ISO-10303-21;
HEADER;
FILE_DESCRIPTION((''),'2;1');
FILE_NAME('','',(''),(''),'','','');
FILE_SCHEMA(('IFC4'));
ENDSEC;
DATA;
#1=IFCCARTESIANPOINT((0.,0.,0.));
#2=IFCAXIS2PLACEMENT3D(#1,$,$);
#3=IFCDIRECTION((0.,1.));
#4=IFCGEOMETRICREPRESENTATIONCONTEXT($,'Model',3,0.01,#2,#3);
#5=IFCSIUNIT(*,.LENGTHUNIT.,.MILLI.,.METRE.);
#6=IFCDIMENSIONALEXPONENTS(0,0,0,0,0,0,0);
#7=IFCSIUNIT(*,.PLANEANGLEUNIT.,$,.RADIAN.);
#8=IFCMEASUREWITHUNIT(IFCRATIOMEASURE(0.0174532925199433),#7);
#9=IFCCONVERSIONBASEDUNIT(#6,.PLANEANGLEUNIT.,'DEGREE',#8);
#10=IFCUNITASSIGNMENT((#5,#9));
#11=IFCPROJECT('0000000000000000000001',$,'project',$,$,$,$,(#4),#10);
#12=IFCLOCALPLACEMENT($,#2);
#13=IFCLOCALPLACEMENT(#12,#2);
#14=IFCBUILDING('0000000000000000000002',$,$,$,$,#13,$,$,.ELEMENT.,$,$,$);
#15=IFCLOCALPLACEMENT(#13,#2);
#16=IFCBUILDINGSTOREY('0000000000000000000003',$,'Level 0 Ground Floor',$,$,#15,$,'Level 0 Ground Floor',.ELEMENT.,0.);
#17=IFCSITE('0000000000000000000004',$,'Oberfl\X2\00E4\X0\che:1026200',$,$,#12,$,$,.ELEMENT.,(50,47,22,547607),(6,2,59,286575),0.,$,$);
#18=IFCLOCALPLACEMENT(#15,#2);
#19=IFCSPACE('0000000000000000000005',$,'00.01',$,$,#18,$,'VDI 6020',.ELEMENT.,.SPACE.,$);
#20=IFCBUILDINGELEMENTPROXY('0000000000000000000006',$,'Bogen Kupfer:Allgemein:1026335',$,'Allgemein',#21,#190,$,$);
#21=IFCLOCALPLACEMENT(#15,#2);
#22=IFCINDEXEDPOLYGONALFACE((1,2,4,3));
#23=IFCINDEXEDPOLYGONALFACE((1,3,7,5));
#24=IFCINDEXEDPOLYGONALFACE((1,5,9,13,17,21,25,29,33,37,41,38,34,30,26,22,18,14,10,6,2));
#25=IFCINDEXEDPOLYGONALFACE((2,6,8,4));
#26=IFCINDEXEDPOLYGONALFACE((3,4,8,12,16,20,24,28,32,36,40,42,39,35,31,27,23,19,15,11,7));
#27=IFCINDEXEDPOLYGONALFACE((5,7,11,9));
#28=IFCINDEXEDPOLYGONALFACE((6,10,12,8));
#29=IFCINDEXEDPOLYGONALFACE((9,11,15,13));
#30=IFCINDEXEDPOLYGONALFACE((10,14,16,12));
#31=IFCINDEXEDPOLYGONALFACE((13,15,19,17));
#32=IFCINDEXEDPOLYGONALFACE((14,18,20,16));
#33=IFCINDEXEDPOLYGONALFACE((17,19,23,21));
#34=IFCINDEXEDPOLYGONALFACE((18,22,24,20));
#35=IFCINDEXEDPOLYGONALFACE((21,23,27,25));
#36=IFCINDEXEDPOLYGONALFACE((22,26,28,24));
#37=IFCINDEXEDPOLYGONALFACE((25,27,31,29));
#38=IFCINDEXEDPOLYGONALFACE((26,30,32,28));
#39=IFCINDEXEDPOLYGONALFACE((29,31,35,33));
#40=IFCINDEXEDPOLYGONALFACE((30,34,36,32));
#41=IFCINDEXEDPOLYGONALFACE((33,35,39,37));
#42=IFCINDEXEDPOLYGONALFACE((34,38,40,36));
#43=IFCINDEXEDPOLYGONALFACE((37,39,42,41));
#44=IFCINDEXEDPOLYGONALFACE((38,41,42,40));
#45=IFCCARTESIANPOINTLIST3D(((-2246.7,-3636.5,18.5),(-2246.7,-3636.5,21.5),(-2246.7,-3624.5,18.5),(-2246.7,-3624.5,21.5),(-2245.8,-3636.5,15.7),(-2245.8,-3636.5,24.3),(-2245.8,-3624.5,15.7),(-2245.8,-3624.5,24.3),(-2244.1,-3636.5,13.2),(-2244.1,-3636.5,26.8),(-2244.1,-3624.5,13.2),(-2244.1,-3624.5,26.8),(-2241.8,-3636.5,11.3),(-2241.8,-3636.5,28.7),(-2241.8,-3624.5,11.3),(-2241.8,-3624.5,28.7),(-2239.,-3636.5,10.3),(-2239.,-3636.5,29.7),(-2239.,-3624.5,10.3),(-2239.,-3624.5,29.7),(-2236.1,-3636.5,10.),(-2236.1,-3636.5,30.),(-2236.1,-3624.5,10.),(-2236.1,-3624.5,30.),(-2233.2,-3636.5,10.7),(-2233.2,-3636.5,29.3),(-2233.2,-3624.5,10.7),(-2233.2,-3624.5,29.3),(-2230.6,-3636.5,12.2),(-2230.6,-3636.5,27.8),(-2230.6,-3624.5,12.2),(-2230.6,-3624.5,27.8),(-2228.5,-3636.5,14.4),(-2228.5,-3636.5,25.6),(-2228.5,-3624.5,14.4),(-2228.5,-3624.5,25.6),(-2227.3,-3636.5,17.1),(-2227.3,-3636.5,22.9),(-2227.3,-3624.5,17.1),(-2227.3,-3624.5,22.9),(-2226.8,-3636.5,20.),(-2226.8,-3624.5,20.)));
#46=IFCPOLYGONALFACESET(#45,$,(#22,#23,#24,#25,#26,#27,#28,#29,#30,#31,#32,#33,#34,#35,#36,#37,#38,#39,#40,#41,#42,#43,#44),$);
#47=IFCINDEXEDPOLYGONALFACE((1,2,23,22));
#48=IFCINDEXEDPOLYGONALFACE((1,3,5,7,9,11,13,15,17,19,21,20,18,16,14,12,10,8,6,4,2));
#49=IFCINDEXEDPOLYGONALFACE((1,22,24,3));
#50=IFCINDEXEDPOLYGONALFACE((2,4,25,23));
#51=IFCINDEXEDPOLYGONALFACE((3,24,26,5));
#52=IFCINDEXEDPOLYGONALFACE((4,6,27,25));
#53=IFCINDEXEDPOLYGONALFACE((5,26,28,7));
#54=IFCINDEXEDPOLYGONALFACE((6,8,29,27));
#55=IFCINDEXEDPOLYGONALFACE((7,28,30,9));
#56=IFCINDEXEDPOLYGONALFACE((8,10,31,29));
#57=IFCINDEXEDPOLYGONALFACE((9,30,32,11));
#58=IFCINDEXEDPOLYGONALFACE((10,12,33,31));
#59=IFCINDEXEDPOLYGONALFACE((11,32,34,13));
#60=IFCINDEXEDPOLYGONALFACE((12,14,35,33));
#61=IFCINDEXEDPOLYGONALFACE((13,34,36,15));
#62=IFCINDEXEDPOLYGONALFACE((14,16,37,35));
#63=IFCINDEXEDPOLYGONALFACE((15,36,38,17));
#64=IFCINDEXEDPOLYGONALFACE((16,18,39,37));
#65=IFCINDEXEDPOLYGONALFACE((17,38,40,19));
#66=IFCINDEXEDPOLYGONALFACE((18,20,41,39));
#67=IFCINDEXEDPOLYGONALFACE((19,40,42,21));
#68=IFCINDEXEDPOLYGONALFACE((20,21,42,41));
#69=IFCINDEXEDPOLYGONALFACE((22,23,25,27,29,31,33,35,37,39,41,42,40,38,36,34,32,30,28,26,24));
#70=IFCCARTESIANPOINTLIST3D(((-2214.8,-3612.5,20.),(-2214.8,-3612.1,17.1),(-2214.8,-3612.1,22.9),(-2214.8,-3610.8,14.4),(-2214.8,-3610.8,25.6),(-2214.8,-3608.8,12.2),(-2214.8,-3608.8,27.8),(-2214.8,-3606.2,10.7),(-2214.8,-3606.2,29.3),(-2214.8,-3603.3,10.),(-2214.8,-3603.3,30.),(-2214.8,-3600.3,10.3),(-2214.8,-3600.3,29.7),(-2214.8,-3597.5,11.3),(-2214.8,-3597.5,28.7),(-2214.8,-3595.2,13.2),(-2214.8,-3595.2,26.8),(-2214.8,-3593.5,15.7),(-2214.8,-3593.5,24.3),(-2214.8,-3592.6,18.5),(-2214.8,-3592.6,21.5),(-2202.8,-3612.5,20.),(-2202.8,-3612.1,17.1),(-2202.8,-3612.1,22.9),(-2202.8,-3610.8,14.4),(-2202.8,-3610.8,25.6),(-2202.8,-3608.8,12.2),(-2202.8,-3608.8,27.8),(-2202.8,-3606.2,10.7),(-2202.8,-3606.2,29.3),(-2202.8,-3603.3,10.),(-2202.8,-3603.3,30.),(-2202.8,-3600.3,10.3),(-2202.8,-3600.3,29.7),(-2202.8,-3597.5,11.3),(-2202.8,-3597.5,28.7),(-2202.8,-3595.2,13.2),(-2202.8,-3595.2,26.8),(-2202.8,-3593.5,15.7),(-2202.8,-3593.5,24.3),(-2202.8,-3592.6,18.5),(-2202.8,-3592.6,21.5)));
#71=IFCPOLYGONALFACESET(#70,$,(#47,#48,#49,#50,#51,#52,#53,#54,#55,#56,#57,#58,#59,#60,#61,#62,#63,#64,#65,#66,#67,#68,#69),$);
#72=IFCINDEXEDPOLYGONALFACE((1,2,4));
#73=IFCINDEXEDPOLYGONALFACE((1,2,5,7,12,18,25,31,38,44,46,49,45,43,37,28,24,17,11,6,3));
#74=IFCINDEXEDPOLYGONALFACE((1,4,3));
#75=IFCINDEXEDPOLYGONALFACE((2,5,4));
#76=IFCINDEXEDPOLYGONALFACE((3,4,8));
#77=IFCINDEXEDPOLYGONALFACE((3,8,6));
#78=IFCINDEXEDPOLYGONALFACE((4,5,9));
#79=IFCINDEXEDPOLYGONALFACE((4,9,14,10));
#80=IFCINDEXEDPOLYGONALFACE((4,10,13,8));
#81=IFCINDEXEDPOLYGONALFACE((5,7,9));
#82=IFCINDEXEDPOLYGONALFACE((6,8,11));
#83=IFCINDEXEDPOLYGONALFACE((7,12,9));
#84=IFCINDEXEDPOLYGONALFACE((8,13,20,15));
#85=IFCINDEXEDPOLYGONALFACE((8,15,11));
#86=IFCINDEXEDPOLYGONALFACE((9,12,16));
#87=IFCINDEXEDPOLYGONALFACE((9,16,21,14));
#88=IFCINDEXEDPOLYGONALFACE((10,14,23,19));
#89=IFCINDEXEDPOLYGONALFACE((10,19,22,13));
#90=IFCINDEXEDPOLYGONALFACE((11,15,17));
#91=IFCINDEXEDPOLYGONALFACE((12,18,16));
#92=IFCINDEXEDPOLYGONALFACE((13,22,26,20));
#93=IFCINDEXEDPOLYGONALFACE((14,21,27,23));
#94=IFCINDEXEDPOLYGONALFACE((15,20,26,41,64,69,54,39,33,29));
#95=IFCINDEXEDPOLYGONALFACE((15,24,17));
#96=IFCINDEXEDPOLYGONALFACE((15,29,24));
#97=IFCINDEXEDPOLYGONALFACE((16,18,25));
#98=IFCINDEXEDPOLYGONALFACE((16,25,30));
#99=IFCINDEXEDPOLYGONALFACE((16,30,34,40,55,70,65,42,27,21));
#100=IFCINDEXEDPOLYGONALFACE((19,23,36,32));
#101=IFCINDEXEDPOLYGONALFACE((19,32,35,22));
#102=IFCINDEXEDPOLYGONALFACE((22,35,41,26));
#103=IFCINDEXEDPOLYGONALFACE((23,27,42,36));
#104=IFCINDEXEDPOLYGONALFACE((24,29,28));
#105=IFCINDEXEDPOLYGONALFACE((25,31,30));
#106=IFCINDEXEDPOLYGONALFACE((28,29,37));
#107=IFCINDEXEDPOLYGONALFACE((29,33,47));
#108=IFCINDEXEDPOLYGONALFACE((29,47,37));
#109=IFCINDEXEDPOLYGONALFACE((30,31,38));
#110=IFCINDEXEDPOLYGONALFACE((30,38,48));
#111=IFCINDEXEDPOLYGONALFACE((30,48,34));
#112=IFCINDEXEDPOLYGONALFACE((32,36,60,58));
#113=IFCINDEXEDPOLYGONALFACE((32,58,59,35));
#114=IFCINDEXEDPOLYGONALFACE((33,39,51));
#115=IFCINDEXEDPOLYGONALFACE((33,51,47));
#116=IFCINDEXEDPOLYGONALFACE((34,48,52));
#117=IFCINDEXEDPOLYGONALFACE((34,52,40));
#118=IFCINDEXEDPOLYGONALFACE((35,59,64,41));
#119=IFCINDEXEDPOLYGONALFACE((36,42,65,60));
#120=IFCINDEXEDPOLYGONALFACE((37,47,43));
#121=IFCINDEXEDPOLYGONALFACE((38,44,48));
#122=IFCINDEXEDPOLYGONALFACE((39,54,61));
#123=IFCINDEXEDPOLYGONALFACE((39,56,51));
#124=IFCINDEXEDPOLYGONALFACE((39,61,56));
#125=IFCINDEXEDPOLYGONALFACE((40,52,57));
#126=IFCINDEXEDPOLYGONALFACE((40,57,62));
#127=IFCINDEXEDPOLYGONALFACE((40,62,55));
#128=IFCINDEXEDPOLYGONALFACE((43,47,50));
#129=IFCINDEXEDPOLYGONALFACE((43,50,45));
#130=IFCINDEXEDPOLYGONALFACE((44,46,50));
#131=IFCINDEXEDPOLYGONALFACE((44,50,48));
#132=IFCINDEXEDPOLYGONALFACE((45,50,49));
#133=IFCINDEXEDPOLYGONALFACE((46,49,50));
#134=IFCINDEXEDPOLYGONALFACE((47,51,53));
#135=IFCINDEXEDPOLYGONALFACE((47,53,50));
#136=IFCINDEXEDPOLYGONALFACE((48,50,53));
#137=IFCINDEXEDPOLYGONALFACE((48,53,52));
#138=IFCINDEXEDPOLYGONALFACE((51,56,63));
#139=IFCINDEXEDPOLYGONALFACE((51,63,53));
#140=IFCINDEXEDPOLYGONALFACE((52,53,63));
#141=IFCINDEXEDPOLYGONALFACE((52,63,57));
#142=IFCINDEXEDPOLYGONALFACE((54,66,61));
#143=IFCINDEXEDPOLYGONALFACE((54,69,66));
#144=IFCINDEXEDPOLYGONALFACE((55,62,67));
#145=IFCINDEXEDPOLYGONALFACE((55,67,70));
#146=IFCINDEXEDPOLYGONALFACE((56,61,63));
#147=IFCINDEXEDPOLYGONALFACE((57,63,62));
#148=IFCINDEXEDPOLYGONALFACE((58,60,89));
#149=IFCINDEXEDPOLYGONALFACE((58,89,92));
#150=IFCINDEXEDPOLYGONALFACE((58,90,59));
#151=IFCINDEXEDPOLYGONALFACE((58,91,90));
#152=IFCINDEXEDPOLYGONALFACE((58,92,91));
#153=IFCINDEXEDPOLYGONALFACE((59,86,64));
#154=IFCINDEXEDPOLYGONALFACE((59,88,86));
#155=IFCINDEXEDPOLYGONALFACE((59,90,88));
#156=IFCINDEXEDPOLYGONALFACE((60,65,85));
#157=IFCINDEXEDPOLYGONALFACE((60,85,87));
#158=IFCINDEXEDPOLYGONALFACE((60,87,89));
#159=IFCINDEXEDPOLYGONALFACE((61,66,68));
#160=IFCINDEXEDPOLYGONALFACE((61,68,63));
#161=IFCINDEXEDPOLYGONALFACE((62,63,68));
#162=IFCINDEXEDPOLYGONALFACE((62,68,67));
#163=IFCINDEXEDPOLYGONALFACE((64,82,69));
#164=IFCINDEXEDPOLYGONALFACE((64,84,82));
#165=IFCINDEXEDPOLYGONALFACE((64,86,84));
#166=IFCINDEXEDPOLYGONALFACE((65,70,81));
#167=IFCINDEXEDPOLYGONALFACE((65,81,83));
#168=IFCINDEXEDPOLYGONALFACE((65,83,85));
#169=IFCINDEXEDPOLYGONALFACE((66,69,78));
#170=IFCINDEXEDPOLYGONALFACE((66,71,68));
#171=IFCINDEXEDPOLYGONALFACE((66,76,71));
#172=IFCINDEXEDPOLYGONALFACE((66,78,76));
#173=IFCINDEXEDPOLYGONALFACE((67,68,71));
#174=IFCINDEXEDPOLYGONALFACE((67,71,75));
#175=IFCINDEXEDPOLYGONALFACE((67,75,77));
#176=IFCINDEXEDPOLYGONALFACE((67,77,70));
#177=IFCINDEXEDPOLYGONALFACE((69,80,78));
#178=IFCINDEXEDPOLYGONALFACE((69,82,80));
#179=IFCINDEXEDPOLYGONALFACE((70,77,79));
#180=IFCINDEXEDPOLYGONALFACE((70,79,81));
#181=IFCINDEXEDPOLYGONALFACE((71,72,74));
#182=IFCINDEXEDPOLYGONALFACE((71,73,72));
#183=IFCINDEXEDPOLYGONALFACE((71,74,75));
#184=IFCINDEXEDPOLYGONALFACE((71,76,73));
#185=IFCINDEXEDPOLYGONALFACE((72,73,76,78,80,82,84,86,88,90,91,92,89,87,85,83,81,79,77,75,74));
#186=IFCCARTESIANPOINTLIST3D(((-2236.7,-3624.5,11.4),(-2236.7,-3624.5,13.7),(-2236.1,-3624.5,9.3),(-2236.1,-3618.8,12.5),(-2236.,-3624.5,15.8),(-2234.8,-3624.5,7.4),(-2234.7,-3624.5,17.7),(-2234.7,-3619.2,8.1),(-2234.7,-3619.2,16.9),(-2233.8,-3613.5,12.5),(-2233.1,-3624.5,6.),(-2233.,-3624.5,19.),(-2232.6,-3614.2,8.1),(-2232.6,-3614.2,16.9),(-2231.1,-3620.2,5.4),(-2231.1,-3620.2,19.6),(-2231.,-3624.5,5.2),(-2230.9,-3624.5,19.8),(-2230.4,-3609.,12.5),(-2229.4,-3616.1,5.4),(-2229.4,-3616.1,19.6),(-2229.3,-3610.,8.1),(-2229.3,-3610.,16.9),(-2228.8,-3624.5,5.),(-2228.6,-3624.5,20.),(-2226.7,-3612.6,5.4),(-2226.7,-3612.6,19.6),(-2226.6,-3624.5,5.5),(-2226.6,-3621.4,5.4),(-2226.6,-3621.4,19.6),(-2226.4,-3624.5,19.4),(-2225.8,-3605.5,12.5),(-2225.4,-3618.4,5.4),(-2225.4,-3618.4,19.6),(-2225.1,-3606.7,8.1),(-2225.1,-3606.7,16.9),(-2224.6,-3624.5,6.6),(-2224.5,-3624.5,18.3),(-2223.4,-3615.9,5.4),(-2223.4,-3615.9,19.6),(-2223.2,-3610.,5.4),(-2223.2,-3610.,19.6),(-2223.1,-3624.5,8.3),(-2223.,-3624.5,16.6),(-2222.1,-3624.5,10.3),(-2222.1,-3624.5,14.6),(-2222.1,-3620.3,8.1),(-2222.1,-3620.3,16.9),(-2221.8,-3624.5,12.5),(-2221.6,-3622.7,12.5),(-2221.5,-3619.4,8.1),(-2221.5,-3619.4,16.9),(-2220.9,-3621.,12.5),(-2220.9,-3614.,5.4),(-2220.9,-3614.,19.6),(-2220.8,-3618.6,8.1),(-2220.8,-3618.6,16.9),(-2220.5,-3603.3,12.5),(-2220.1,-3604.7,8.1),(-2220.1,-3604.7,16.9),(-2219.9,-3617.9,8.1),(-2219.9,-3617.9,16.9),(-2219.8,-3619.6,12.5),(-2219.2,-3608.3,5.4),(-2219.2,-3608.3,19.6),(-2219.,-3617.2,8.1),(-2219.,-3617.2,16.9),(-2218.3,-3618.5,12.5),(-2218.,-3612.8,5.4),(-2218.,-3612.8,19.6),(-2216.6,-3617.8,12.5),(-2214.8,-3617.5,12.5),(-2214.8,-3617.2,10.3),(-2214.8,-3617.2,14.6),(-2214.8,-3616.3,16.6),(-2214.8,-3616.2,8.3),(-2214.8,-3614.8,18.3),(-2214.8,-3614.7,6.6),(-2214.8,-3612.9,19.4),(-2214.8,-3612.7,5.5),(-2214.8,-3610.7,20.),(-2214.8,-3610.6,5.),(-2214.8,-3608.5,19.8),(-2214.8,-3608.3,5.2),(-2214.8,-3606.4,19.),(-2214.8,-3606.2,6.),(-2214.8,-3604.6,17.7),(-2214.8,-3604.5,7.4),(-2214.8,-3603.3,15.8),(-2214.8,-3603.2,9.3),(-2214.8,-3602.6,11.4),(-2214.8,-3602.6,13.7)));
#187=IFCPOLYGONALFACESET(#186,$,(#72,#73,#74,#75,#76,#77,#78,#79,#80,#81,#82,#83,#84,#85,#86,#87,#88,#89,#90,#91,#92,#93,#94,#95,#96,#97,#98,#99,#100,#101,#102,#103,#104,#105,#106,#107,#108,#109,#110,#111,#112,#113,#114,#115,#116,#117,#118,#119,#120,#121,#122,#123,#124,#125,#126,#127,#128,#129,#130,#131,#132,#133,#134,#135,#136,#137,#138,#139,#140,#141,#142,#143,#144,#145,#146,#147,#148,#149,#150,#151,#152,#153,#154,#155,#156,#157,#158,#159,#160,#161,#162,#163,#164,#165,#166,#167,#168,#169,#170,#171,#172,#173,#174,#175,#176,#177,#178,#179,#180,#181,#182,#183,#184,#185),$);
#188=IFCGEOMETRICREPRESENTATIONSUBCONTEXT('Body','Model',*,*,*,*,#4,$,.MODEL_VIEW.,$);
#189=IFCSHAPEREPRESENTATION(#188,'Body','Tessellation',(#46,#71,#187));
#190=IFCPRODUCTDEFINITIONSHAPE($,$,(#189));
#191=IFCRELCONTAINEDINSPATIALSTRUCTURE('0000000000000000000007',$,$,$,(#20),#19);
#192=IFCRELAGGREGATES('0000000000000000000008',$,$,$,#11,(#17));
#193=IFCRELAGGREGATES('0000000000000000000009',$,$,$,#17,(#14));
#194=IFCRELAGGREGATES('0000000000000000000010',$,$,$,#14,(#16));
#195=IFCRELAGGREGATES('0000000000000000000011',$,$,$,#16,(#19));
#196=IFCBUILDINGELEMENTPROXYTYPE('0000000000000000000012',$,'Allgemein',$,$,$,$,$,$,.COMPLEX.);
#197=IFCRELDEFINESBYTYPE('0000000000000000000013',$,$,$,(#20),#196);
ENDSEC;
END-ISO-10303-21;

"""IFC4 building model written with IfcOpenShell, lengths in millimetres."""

from ifc_helpers import new_model, entity, si_unit, converted_unit, direction, frame, frame_2d, origin, place, context, subcontext, project, spatial, circle, extrude, source, transform, mapped, type_object, type_shapes, element, save


model = new_model("IFC4")

# Units and contexts
model_context = context("Model", 3, precision=0.01, world=origin(), true_north=direction((0.0, 1.0)))
body_context = subcontext(model_context, "Body", "Model", "MODEL_VIEW")
ifc_project = project(units=[si_unit("LENGTHUNIT", "METRE", prefix="MILLI"), converted_unit("PLANEANGLEUNIT", "DEGREE", entity("IfcRatioMeasure", 0.0174532925199433), si_unit("PLANEANGLEUNIT", "RADIAN"), dimensions=[0, 0, 0, 0, 0, 0, 0])], contexts=[model_context])

# Site, building, storey
site_placement = place(None, origin())
site = spatial("IfcSite", under=ifc_project, at=site_placement, Name="Oberfläche:1026200", CompositionType="ELEMENT", RefLatitude=(50, 47, 22, 547607), RefLongitude=(6, 2, 59, 286575), RefElevation=0.0)
building_placement = place(site_placement, origin())
building = spatial("IfcBuilding", under=site, at=building_placement, CompositionType="ELEMENT")
storey_placement = place(building_placement, origin())
storey = spatial("IfcBuildingStorey", under=building, at=storey_placement, Name="Level 0 Ground Floor", LongName="Level 0 Ground Floor", CompositionType="ELEMENT", Elevation=0.0)

# Shared definitions
space_placement = place(storey_placement, origin())
space = spatial("IfcSpace", under=storey, at=space_placement, Name="00.01", LongName="VDI 6020", CompositionType="ELEMENT", PredefinedType="SPACE")

# Building element proxy
building_element_proxy_type = type_object("IfcBuildingElementProxyType", Name="Allgemein", PredefinedType="COMPLEX")
ifc_direction = entity("IfcDirection", [0.0, 0.0, -1.0])
trimmed_curve = entity("IfcTrimmedCurve", entity("IfcCircle", entity("IfcAxis2Placement2D", entity("IfcCartesianPoint", [-14.5, 0.0]), entity("IfcDirection", [0.0, 1.0])), 14.5), [entity("IfcParameterValue", 270.0)], [entity("IfcParameterValue", 0.0)], True, "PARAMETER")
shared_shape_1 = source(origin(), body_context, "Body", "SolidModel", [
    extrude(circle(Radius=10.0, at=frame_2d((0.0, 0.0), x_axis=(1.0, 0.0))), frame((0.0, 22.0, 0.0), z_axis=(0.0, 1.0, 0.0), x_axis=(-1.0, 0.0, 0.0)), (0.0, 0.0, 1.0), 12.0),
    extrude(circle(Radius=10.0, at=frame_2d((0.0, 0.0), x_axis=(1.0, 0.0))), frame((-34.0, 0.0, 0.0), z_axis=(1.0, 0.0, 0.0), x_axis=(0.0, 1.0, 0.0)), (0.0, 0.0, 1.0), 12.0),
    entity("IfcSurfaceCurveSweptAreaSolid", entity("IfcCircleProfileDef", "AREA", None, entity("IfcAxis2Placement2D", entity("IfcCartesianPoint", [0.0, 7.5]), entity("IfcDirection", [1.0, 0.0])), 7.5), entity("IfcAxis2Placement3D", entity("IfcCartesianPoint", [-7.5, 22.0, 0.0]), ifc_direction, entity("IfcDirection", [1.0, 0.0, 0.0])), trimmed_curve, 0.0, 90.0, entity("IfcSurfaceOfLinearExtrusion", entity("IfcArbitraryOpenProfileDef", "CURVE", None, trimmed_curve), entity("IfcAxis2Placement3D", entity("IfcCartesianPoint", [0.0, 0.0, -304.8])), ifc_direction, 1.0)),
])
type_shapes(building_element_proxy_type, [shared_shape_1])
for number, where, z_axis, x_axis, name in (
    (1, (-2236.8, -3602.5, 20.0), (0.0, 0.0, 1.0), (-1.0, 0.0, 0.0), "Bogen Kupfer:Allgemein:1026335"),
):
    element("IfcBuildingElementProxy", number, at=place(space_placement, frame(where, z_axis=z_axis, x_axis=x_axis)), inside=space, type_object=building_element_proxy_type, Name=name, ObjectType="Allgemein", context=body_context, shape_type="MappedRepresentation", body=[
        mapped(shared_shape_1, transform((0.0, 0.0, 0.0), scale=1.0)),
    ])

save(model, "model.ifc")
